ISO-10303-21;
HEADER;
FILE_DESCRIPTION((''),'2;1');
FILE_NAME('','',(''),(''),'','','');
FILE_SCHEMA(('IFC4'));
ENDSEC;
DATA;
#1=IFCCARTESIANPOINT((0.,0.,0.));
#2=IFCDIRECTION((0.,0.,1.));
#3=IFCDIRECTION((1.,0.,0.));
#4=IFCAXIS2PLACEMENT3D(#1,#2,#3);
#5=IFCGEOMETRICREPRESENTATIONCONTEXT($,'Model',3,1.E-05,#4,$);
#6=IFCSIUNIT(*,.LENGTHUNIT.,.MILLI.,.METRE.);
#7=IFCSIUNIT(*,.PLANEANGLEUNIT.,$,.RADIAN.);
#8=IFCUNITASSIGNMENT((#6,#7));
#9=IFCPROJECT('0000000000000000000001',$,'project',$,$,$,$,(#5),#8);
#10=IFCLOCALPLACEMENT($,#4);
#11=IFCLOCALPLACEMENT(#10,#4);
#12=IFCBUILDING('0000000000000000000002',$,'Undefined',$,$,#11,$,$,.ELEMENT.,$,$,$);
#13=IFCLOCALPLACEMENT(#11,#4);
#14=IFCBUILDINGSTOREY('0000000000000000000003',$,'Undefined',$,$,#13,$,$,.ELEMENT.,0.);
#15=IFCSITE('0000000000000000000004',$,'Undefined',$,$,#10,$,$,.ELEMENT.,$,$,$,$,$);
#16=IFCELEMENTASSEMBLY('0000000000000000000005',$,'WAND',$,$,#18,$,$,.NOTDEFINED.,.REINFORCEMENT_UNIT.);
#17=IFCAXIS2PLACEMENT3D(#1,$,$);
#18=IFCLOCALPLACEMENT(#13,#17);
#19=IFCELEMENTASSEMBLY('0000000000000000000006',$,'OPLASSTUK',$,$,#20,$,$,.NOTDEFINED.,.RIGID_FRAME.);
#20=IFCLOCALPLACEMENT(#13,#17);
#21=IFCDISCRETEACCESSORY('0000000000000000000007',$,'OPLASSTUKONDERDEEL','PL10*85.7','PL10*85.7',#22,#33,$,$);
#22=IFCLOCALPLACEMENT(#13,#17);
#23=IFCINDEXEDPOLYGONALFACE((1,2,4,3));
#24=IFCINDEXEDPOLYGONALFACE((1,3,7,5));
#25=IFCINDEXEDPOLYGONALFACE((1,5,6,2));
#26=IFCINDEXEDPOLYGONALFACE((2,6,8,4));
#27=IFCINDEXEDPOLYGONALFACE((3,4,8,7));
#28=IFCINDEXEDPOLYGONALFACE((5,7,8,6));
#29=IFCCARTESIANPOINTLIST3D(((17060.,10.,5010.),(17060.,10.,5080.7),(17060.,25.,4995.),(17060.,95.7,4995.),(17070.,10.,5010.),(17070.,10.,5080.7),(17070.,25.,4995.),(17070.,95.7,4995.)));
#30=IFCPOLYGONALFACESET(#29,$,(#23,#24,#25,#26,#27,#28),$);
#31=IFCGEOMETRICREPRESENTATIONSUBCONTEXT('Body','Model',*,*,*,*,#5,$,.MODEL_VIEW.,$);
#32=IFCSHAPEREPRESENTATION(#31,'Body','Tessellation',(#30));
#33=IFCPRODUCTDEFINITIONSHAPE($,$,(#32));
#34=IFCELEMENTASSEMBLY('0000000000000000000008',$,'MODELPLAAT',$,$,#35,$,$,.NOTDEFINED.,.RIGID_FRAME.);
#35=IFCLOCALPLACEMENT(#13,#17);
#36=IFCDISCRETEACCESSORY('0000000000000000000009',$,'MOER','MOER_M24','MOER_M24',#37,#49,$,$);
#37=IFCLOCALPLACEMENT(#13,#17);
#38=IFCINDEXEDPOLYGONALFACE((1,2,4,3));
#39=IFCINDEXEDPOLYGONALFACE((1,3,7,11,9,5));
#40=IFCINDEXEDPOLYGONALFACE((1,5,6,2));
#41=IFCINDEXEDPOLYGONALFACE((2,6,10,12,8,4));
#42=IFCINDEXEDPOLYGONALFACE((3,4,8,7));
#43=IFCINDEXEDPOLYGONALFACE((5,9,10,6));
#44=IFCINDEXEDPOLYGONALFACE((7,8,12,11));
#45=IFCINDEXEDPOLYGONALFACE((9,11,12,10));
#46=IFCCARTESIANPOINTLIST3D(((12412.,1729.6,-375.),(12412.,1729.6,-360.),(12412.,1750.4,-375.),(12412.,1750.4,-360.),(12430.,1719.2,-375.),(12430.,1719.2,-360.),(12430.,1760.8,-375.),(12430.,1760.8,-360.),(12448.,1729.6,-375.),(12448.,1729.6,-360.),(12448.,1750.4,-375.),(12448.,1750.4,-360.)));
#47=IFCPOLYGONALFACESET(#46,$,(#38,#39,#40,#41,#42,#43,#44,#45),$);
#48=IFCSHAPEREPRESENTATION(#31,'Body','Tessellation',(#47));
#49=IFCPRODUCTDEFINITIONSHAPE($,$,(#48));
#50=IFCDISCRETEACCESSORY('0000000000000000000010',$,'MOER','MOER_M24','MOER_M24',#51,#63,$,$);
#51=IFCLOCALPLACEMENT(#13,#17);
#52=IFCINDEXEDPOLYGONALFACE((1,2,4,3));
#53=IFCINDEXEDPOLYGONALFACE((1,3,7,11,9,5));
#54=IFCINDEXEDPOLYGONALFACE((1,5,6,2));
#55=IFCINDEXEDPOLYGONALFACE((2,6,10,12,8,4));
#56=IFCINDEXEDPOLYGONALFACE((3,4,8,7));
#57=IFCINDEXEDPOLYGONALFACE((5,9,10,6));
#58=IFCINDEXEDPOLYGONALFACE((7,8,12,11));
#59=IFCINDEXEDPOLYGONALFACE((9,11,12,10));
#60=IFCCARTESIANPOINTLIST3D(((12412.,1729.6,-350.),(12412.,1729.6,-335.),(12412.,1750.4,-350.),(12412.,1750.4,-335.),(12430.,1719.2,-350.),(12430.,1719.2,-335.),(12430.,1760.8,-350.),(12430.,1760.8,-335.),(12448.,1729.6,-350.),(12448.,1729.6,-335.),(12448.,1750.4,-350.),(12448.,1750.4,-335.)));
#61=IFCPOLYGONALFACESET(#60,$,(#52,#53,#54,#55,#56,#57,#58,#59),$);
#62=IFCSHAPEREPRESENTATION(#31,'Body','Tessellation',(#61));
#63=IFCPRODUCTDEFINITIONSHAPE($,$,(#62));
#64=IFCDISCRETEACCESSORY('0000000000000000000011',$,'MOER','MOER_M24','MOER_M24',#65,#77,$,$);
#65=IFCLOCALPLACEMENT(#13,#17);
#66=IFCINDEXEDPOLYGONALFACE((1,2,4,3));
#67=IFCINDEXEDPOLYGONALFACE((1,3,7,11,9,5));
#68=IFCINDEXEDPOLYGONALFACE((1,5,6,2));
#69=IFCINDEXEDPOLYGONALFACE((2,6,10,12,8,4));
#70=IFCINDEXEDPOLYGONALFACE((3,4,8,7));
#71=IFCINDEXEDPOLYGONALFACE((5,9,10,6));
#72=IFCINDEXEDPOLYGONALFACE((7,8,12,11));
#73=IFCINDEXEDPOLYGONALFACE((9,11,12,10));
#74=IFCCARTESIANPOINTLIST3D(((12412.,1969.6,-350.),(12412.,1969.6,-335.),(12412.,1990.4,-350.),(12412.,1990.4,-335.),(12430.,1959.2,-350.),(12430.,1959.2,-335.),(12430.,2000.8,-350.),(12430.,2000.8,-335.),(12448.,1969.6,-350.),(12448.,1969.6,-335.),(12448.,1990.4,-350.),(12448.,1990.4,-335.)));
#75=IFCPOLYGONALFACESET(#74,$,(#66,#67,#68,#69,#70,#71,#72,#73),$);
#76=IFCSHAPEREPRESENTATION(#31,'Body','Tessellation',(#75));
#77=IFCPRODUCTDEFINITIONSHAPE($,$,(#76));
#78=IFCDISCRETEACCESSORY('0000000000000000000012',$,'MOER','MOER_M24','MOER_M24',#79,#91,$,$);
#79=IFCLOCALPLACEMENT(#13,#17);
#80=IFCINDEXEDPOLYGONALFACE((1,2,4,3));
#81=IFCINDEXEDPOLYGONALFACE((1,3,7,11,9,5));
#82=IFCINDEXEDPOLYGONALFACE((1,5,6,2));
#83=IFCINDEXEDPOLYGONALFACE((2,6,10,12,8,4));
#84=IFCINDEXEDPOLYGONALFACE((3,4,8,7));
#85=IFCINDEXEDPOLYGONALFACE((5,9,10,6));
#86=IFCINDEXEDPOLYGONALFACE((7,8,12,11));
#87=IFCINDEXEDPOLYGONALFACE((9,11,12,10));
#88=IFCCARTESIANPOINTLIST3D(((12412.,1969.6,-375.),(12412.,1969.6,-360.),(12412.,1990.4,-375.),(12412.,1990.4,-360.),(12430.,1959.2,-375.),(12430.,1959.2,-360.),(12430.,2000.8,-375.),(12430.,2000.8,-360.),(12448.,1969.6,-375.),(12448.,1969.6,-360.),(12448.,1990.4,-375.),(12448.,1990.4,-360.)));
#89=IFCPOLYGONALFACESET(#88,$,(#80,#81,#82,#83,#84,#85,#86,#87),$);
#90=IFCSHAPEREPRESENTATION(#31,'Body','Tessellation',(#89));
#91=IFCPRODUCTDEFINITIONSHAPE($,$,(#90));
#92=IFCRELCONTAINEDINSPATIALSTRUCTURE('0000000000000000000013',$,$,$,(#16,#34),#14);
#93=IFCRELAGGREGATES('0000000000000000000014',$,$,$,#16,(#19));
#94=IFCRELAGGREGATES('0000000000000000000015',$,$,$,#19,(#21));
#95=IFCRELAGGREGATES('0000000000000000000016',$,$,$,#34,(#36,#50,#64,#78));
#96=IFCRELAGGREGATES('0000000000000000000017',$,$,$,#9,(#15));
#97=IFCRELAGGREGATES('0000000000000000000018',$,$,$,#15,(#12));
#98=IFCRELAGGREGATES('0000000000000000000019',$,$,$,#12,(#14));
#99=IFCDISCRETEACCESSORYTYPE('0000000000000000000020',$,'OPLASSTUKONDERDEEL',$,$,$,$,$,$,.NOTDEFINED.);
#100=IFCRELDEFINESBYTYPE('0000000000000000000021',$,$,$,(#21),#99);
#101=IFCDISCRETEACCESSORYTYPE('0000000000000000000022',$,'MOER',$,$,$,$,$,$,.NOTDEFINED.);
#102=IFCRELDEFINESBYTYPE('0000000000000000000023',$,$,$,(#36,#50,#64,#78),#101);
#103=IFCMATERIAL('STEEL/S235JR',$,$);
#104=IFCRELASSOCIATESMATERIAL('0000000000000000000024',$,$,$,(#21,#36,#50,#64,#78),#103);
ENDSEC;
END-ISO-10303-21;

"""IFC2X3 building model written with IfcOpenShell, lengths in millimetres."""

from ifc_helpers import new_model, si_unit, frame, origin_with_axes, place, context, subcontext, project, spatial, polyline, outline, extrude, material, type_object, element, aggregate, save


model = new_model("IFC2X3")

# Units and contexts
model_context = context("Model", 3, precision=1e-05, world=origin_with_axes())
body_context = subcontext(model_context, "Body", "Model", "MODEL_VIEW")
ifc_project = project(units=[si_unit("LENGTHUNIT", "METRE", prefix="MILLI"), si_unit("PLANEANGLEUNIT", "RADIAN")], contexts=[model_context])

# Site, building, storey
site_placement = place(None, origin_with_axes())
site = spatial("IfcSite", under=ifc_project, at=site_placement, Name="Undefined", CompositionType="ELEMENT")
building_placement = place(site_placement, origin_with_axes())
building = spatial("IfcBuilding", under=site, at=building_placement, Name="Undefined", CompositionType="ELEMENT")
storey_placement = place(building_placement, origin_with_axes())
storey = spatial("IfcBuildingStorey", under=building, at=storey_placement, Name="Undefined", CompositionType="ELEMENT", Elevation=0.0)

# Shared definitions
ifc_material_1 = material(Name="STEEL/S235JR")

# Element assemblies
assembly_1_placement = place(storey_placement, origin_with_axes())
assembly_1 = element("IfcElementAssembly", 1, at=assembly_1_placement, inside=storey, Name="WAND", AssemblyPlace="NOTDEFINED", PredefinedType="REINFORCEMENT_UNIT")
assembly_2_placement = place(assembly_1_placement, origin_with_axes())
assembly_2 = element("IfcElementAssembly", 2, at=assembly_2_placement, Name="OPLASSTUK", AssemblyPlace="NOTDEFINED", PredefinedType="RIGID_FRAME")
aggregate(assembly_1, [assembly_2])

# Discrete accessory
discrete_accessory_type_1 = type_object("IfcDiscreteAccessoryType", Name="OPLASSTUKONDERDEEL")
discrete_accessory_1_placement = place(assembly_2_placement, frame((17065.0, 10.0, 5080.7), z_axis=(1.0, 0.0, 0.0), x_axis=(0.0, 0.0, -1.0)))
discrete_accessory_1 = element("IfcDiscreteAccessory", 3, at=discrete_accessory_1_placement, type_object=discrete_accessory_type_1, material=ifc_material_1, Name="OPLASSTUKONDERDEEL", Description="PL10*85.7", ObjectType="PL10*85.7", context=body_context, shape_type="SweptSolid", body=[
    extrude(outline(polyline([(0.0, 0.0), (70.7, 0.0), (85.7, 15.0), (85.7, 85.7), (0.0, 0.0)])), frame((0.0, 0.0, -5.0), z_axis=(0.0, 0.0, 1.0), x_axis=(1.0, 0.0, 0.0)), (0.0, 0.0, 1.0), 10.0),
])
aggregate(assembly_2, [discrete_accessory_1])

# Element assembly, discrete accessories
assembly_3_placement = place(storey_placement, origin_with_axes())
assembly_3 = element("IfcElementAssembly", 4, at=assembly_3_placement, inside=storey, Name="MODELPLAAT", AssemblyPlace="NOTDEFINED", PredefinedType="RIGID_FRAME")
discrete_accessory_type_2 = type_object("IfcDiscreteAccessoryType", Name="MOER")
discrete_accessory_2_placement = place(assembly_3_placement, frame((12430.0, 1740.0, -360.0), z_axis=(0.0, 1.0, 0.0), x_axis=(0.0, 0.0, -1.0)))
discrete_accessory_2 = element("IfcDiscreteAccessory", 5, at=discrete_accessory_2_placement, type_object=discrete_accessory_type_2, material=ifc_material_1, Name="MOER", Description="MOER_M24", ObjectType="MOER_M24", context=body_context, shape_type="SweptSolid", body=[
    extrude(outline(polyline([(0.0, -20.8), (-18.0, -10.4), (-18.0, 10.4), (0.0, 20.8), (18.0, 10.4), (18.0, -10.4), (0.0, -20.8)])), frame((15.0, 0.0, 0.0), z_axis=(-1.0, 0.0, 0.0), x_axis=(0.0, -1.0, 0.0)), (0.0, 0.0, 1.0), 15.0),
])
discrete_accessory_3_placement = place(assembly_3_placement, frame((12430.0, 1740.0, -350.0), z_axis=(0.0, 1.0, 0.0), x_axis=(0.0, 0.0, 1.0)))
discrete_accessory_3 = element("IfcDiscreteAccessory", 6, at=discrete_accessory_3_placement, type_object=discrete_accessory_type_2, material=ifc_material_1, Name="MOER", Description="MOER_M24", ObjectType="MOER_M24", context=body_context, shape_type="SweptSolid", body=[
    extrude(outline(polyline([(0.0, -20.8), (-18.0, -10.4), (-18.0, 10.4), (0.0, 20.8), (18.0, 10.4), (18.0, -10.4), (0.0, -20.8)])), frame((15.0, 0.0, 0.0), z_axis=(-1.0, 0.0, 0.0), x_axis=(0.0, -1.0, 0.0)), (0.0, 0.0, 1.0), 15.0),
])
discrete_accessory_4_placement = place(assembly_3_placement, frame((12430.0, 1980.0, -350.0), z_axis=(0.0, 1.0, 0.0), x_axis=(0.0, 0.0, 1.0)))
discrete_accessory_4 = element("IfcDiscreteAccessory", 7, at=discrete_accessory_4_placement, type_object=discrete_accessory_type_2, material=ifc_material_1, Name="MOER", Description="MOER_M24", ObjectType="MOER_M24", context=body_context, shape_type="SweptSolid", body=[
    extrude(outline(polyline([(0.0, -20.8), (-18.0, -10.4), (-18.0, 10.4), (0.0, 20.8), (18.0, 10.4), (18.0, -10.4), (0.0, -20.8)])), frame((15.0, 0.0, 0.0), z_axis=(-1.0, 0.0, 0.0), x_axis=(0.0, -1.0, 0.0)), (0.0, 0.0, 1.0), 15.0),
])
discrete_accessory_5_placement = place(assembly_3_placement, frame((12430.0, 1980.0, -360.0), z_axis=(0.0, 1.0, 0.0), x_axis=(0.0, 0.0, -1.0)))
discrete_accessory_5 = element("IfcDiscreteAccessory", 8, at=discrete_accessory_5_placement, type_object=discrete_accessory_type_2, material=ifc_material_1, Name="MOER", Description="MOER_M24", ObjectType="MOER_M24", context=body_context, shape_type="SweptSolid", body=[
    extrude(outline(polyline([(0.0, -20.8), (-18.0, -10.4), (-18.0, 10.4), (0.0, 20.8), (18.0, 10.4), (18.0, -10.4), (0.0, -20.8)])), frame((15.0, 0.0, 0.0), z_axis=(-1.0, 0.0, 0.0), x_axis=(0.0, -1.0, 0.0)), (0.0, 0.0, 1.0), 15.0),
])
aggregate(assembly_3, [discrete_accessory_2, discrete_accessory_3, discrete_accessory_4, discrete_accessory_5])

save(model, "model.ifc")
